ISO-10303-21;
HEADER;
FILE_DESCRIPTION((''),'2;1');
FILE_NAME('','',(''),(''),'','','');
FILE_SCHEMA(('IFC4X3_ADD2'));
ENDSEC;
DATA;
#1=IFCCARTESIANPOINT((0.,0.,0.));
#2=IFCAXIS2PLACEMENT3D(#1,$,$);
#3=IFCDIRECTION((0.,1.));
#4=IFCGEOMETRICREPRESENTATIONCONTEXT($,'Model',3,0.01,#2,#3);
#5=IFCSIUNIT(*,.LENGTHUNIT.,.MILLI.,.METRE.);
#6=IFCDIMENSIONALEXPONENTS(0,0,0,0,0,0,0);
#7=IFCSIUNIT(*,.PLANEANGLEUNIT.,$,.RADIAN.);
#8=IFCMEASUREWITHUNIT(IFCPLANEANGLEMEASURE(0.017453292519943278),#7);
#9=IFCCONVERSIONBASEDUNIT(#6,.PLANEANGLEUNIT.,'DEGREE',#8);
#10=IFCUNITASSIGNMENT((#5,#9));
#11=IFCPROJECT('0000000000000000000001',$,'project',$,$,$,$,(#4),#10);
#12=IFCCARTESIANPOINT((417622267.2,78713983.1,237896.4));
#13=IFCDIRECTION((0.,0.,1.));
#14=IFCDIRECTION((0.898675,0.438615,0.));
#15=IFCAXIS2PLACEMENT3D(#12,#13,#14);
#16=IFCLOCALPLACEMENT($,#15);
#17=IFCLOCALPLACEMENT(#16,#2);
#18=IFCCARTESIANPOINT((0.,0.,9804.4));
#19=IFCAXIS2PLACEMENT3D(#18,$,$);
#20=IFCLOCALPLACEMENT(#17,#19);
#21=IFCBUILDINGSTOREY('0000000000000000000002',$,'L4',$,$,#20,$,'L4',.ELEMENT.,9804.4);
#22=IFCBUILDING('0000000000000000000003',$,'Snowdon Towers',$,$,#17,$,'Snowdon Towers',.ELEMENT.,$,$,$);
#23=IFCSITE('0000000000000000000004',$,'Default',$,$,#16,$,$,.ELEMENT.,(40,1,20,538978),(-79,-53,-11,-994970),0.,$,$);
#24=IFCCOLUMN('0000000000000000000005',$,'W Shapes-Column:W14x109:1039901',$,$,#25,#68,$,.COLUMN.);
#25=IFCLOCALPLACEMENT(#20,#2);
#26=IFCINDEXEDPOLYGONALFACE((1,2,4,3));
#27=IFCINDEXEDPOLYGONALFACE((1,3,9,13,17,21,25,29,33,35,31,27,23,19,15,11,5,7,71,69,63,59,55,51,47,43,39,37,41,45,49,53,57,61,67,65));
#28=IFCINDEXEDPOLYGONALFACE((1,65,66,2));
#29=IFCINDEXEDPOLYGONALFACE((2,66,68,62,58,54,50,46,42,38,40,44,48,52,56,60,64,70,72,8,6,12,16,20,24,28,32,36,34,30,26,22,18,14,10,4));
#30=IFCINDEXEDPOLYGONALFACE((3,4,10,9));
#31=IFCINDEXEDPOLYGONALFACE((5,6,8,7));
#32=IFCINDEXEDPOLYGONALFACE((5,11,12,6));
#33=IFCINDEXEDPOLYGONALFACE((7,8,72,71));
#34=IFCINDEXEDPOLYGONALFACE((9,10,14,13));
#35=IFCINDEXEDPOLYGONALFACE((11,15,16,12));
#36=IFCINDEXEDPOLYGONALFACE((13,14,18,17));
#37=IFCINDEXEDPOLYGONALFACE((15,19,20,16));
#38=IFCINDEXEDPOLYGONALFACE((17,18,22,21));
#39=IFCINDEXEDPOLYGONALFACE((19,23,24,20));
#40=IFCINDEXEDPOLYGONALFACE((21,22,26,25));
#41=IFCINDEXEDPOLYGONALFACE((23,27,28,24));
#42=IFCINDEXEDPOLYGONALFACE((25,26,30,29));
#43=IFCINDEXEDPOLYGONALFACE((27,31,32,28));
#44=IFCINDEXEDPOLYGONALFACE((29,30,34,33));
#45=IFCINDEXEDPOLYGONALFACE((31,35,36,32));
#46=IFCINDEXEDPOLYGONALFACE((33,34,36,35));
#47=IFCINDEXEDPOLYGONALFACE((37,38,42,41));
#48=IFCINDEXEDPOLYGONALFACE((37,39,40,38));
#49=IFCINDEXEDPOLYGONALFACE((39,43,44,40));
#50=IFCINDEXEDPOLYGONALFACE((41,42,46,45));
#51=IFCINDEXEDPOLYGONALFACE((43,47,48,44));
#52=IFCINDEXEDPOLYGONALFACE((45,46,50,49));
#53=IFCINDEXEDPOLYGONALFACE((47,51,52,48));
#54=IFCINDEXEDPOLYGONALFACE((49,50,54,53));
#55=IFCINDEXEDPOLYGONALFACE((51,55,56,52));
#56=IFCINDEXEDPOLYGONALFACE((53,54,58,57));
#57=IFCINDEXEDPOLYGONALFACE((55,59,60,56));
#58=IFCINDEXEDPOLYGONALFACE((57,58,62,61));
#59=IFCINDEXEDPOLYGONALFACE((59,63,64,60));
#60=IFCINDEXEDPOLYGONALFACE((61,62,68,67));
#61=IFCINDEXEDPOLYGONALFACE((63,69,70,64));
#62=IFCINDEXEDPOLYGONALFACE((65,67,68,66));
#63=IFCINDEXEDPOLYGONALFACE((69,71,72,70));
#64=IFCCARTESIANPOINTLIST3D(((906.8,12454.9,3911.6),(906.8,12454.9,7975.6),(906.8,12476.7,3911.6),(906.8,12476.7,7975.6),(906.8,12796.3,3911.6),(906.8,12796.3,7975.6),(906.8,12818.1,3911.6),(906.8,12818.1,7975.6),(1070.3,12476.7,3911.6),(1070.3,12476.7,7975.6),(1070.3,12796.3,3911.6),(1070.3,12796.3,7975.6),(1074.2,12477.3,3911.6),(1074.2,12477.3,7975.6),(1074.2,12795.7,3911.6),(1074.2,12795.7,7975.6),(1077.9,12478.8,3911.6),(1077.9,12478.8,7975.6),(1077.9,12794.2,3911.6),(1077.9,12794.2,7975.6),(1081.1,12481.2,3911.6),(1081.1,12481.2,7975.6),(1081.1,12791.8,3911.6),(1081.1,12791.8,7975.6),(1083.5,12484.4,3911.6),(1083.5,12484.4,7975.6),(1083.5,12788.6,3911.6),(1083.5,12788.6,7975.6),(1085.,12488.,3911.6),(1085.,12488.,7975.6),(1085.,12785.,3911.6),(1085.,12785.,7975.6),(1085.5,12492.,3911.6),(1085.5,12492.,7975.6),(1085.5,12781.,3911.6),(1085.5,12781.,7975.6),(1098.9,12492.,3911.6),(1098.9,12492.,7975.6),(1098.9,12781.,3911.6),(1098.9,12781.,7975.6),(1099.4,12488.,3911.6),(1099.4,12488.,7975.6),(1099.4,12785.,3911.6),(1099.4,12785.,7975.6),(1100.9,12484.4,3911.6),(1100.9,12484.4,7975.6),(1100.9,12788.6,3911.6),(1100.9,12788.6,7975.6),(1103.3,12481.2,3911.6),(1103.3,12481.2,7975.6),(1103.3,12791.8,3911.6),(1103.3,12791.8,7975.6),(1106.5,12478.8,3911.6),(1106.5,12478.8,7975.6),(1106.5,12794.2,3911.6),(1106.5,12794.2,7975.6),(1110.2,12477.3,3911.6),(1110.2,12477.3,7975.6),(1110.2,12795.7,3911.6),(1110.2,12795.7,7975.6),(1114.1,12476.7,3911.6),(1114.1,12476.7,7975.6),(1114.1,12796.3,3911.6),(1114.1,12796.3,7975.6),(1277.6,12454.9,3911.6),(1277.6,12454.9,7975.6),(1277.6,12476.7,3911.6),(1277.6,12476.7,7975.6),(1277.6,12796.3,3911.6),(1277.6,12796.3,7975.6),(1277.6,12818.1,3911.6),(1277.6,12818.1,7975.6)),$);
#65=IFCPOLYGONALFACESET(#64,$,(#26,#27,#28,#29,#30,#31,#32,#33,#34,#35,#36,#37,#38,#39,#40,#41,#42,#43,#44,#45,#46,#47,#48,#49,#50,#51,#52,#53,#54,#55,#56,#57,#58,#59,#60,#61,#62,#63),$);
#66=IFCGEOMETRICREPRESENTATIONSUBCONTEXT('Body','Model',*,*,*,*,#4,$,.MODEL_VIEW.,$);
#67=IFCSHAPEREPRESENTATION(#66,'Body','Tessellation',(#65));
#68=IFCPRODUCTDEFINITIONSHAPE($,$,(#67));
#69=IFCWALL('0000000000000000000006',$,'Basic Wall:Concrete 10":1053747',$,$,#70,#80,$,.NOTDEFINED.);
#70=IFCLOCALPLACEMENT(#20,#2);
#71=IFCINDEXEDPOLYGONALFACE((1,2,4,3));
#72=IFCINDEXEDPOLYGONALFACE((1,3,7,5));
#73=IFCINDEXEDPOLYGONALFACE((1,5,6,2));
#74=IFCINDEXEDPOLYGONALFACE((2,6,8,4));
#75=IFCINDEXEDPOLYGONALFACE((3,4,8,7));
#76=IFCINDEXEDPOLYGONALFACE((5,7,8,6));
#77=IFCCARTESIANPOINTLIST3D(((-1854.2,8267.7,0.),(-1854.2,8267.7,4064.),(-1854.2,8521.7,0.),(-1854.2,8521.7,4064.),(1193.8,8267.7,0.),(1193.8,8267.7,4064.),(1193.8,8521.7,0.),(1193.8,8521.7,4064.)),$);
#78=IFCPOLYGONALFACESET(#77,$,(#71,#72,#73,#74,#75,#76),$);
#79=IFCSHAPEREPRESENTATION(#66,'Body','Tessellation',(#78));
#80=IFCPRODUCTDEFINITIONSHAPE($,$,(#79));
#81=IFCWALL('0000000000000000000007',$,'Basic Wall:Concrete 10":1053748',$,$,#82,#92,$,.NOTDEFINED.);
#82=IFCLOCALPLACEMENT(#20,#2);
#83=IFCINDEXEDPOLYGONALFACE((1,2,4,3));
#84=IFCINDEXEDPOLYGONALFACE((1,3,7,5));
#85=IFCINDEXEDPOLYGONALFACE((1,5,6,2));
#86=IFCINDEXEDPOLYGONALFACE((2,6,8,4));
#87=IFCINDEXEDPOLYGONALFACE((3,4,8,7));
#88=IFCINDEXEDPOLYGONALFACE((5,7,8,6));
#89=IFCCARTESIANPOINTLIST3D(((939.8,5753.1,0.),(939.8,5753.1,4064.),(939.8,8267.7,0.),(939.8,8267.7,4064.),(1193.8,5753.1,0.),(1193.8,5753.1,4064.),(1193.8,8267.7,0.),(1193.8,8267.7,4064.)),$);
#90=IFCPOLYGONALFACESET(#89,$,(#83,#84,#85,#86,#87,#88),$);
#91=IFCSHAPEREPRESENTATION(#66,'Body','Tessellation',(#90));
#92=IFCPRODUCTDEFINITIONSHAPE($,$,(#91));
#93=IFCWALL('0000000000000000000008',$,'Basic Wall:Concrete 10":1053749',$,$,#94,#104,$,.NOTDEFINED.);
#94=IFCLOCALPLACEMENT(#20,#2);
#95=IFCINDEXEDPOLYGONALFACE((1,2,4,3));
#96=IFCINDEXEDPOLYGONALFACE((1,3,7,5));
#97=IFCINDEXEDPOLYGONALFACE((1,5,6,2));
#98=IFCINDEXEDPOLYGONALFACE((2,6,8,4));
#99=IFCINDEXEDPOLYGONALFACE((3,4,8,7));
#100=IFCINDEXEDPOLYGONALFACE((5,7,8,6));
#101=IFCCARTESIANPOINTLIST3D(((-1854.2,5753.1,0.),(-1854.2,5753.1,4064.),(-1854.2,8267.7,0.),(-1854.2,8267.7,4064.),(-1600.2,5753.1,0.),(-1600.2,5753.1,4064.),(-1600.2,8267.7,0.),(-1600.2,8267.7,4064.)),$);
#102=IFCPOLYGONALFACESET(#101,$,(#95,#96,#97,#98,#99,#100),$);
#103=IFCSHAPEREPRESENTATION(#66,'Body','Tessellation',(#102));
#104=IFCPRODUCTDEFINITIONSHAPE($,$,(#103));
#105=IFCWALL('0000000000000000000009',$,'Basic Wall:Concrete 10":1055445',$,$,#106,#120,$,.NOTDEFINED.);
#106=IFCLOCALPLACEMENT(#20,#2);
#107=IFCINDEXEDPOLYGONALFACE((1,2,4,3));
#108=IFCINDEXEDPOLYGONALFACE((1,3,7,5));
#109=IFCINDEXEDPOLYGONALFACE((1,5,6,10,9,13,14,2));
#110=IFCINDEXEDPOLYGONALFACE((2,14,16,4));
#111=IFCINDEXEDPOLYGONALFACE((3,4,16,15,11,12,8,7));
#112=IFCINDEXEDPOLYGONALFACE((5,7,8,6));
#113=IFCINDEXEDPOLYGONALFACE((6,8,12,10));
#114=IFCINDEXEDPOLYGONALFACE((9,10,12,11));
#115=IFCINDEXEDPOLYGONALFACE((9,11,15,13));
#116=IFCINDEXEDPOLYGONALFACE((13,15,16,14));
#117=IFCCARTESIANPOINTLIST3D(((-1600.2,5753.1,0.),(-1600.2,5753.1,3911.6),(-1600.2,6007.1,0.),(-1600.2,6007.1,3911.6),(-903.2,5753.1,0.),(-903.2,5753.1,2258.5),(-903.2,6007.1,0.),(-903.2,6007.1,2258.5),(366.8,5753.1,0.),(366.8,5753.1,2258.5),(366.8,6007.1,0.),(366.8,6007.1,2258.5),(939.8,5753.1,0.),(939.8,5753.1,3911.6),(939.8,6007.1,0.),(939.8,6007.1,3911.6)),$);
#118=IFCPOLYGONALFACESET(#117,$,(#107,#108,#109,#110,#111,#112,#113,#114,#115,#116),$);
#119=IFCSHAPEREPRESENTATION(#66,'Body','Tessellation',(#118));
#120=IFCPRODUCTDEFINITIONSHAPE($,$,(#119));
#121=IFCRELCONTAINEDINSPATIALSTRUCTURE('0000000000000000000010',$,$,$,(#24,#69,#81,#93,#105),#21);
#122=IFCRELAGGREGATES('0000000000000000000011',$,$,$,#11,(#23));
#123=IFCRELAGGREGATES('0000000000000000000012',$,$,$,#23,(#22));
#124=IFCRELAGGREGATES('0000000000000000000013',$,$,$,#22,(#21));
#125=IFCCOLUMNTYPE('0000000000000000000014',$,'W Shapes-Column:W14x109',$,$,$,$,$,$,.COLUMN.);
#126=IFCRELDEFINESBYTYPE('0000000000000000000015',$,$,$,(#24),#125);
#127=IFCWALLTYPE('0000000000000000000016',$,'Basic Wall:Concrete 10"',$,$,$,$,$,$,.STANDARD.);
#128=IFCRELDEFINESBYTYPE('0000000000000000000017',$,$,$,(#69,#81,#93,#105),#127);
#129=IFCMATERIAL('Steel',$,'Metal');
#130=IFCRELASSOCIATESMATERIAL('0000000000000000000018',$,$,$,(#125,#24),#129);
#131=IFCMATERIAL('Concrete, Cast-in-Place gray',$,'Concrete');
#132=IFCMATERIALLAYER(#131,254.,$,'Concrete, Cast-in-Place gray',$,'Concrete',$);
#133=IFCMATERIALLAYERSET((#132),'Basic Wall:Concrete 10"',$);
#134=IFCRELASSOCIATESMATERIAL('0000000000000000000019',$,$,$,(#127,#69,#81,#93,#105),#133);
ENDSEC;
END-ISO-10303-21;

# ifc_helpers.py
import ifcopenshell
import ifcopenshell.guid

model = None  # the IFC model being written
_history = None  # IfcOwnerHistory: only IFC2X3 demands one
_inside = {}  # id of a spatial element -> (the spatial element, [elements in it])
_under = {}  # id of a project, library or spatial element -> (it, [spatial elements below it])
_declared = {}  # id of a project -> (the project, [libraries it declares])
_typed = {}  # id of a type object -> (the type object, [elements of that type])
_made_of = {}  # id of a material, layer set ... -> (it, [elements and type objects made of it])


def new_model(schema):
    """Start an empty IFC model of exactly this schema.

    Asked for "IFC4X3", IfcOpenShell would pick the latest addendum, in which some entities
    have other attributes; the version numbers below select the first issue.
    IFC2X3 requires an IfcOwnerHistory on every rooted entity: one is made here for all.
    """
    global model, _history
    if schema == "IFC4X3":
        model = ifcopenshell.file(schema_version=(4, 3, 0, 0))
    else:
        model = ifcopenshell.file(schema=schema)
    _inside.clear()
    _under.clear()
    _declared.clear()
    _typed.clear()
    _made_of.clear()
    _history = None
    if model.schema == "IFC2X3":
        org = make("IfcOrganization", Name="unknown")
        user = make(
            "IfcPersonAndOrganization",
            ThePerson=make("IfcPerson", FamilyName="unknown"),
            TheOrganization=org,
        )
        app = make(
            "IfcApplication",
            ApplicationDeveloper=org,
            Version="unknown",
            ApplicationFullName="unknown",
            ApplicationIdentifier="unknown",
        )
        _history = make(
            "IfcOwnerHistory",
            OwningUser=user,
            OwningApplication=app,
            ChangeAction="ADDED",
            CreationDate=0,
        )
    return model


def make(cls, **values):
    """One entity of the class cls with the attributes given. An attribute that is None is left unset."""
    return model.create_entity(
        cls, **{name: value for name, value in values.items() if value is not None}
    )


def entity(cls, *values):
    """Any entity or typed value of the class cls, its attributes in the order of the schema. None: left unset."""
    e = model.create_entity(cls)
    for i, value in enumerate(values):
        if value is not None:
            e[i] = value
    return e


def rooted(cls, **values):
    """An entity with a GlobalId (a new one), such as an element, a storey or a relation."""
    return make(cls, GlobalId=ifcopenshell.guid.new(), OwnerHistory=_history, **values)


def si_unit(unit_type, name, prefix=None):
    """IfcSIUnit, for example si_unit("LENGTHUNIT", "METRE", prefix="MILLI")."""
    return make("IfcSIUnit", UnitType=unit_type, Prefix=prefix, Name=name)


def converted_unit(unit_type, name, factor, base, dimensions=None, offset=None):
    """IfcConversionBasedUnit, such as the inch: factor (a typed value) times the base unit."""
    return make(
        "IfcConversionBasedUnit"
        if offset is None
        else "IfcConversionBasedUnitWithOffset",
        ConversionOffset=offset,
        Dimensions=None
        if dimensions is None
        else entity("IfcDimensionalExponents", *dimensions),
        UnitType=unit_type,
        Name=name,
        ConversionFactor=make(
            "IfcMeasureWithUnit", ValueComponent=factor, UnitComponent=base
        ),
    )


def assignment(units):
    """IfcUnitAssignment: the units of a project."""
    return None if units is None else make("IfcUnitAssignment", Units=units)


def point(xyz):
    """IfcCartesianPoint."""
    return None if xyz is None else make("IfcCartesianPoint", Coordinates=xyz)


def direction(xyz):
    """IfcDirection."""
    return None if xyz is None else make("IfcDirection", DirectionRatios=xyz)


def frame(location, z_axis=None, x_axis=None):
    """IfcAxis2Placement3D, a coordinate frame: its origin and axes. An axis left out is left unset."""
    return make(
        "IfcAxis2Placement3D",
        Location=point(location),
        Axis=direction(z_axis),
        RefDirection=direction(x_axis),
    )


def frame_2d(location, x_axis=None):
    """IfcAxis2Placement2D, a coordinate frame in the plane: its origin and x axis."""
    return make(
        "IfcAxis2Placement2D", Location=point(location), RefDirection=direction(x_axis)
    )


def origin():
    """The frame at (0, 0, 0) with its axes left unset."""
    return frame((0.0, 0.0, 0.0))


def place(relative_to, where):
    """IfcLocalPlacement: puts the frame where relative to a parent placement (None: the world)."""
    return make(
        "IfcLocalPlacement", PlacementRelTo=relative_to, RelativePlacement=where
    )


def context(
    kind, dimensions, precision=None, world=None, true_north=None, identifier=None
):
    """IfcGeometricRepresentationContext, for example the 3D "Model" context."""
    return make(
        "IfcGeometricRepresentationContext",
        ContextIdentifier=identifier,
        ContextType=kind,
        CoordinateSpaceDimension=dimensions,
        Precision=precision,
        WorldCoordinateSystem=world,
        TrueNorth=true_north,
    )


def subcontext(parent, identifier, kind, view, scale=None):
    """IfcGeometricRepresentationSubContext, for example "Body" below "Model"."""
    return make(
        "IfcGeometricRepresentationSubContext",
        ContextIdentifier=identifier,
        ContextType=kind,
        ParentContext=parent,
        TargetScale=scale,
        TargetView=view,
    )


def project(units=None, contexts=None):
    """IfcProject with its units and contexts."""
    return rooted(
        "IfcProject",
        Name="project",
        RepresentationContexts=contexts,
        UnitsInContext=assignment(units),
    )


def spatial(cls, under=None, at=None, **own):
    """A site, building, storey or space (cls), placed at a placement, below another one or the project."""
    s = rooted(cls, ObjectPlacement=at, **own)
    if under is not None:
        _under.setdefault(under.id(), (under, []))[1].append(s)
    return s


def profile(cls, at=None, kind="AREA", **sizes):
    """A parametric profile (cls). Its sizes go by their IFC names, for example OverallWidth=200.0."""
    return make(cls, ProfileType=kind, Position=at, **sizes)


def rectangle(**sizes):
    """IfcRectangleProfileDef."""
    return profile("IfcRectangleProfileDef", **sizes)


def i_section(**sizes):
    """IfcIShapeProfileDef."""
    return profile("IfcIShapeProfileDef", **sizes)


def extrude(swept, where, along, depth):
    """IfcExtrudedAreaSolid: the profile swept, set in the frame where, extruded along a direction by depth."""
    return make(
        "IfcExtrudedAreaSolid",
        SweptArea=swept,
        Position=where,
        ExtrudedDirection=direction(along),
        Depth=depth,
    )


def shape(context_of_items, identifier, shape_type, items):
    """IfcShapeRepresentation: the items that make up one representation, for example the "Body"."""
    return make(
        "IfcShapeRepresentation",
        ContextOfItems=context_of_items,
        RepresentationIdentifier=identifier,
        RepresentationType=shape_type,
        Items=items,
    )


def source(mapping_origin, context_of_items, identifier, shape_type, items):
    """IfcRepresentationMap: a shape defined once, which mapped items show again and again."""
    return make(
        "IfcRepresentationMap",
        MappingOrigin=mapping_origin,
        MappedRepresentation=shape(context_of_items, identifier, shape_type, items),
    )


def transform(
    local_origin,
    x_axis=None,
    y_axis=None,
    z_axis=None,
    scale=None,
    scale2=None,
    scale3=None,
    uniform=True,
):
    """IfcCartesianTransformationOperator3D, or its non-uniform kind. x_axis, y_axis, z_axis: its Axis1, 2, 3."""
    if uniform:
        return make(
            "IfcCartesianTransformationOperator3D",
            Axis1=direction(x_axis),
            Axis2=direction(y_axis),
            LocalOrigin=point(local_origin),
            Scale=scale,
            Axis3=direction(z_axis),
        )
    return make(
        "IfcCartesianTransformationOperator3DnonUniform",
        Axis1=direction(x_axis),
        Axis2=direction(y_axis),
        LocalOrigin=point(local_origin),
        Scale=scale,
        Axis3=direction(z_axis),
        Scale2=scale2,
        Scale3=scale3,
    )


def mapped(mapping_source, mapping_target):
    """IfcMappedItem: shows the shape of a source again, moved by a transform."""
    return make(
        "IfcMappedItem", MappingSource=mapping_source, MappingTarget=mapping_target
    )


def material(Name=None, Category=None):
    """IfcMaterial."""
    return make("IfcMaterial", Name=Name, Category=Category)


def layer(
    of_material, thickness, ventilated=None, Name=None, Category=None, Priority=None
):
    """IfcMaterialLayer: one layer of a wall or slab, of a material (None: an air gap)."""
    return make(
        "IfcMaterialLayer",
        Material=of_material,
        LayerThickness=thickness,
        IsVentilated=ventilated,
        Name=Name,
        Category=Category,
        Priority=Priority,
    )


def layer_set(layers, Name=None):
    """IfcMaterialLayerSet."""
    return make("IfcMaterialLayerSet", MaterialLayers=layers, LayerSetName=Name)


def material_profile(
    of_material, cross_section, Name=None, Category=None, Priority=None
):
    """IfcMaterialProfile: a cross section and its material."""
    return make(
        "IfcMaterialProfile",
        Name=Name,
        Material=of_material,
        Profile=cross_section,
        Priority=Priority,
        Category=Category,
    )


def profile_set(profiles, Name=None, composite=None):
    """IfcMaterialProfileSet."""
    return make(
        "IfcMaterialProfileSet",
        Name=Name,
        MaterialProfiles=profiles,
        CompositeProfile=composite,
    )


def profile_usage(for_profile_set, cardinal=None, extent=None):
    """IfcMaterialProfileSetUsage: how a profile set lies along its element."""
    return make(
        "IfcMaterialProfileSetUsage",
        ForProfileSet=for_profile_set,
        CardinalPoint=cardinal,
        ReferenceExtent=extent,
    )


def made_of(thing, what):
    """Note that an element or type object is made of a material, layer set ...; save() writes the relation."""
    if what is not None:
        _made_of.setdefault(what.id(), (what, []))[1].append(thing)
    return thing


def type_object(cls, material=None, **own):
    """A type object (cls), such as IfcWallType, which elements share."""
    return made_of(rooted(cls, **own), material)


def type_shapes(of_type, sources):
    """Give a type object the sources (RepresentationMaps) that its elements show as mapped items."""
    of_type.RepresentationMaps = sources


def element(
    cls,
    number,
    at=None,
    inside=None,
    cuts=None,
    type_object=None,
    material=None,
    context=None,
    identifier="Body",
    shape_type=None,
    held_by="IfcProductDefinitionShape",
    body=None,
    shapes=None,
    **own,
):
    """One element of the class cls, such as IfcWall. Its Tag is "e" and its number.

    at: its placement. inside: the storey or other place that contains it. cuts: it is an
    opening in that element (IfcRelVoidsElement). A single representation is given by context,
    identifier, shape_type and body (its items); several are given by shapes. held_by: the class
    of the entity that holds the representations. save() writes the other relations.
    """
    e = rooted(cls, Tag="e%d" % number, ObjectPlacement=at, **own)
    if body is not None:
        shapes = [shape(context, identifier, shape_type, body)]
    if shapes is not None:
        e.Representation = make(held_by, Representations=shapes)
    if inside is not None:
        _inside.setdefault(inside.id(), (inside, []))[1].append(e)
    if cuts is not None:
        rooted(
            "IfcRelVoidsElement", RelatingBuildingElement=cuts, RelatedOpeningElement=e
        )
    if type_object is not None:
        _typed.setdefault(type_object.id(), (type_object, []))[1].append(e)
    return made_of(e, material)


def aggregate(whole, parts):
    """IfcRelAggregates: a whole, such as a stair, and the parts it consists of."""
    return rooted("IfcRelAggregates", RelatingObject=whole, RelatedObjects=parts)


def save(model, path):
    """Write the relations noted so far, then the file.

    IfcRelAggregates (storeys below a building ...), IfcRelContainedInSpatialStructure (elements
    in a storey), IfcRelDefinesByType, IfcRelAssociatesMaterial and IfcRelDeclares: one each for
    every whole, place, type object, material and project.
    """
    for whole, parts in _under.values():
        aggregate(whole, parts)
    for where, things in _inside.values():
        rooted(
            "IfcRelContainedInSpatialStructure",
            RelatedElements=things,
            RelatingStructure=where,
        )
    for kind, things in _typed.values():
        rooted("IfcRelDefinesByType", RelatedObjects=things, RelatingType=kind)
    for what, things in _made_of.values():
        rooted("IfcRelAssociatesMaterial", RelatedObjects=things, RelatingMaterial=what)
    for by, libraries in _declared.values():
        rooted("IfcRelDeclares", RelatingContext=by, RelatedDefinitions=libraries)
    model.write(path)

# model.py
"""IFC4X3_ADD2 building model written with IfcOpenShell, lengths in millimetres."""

from ifc_helpers import new_model, entity, si_unit, converted_unit, direction, frame, frame_2d, origin, place, context, subcontext, project, spatial, rectangle, i_section, extrude, source, transform, mapped, material, layer, layer_set, material_profile, profile_set, profile_usage, type_object, type_shapes, element, save


model = new_model("IFC4X3_ADD2")

# Units and contexts
model_context = context("Model", 3, precision=0.01, world=origin(), true_north=direction((0.0, 1.0)))
body_context = subcontext(model_context, "Body", "Model", "MODEL_VIEW")
ifc_project = project(units=[si_unit("LENGTHUNIT", "METRE", prefix="MILLI"), converted_unit("PLANEANGLEUNIT", "DEGREE", entity("IfcPlaneAngleMeasure", 0.017453292519943278), si_unit("PLANEANGLEUNIT", "RADIAN"), dimensions=[0, 0, 0, 0, 0, 0, 0])], contexts=[model_context])

# Site, building, storey
site_placement = place(None, frame((417622267.2, 78713983.1, 237896.4), z_axis=(0.0, 0.0, 1.0), x_axis=(0.898675, 0.438615, 0.0)))
site = spatial("IfcSite", under=ifc_project, at=site_placement, Name="Default", CompositionType="ELEMENT", RefLatitude=(40, 1, 20, 538978), RefLongitude=(-79, -53, -11, -994970), RefElevation=0.0)
building_placement = place(site_placement, origin())
building = spatial("IfcBuilding", under=site, at=building_placement, Name="Snowdon Towers", LongName="Snowdon Towers", CompositionType="ELEMENT")
storey_placement = place(building_placement, frame((0.0, 0.0, 9804.4)))
storey = spatial("IfcBuildingStorey", under=building, at=storey_placement, Name="L4", LongName="L4", CompositionType="ELEMENT", Elevation=9804.4)

# Column
ifc_material_1 = material(Name="Steel", Category="Metal")
ifc_material_profile_1 = material_profile(ifc_material_1, i_section(OverallWidth=370.8, OverallDepth=363.2, WebThickness=13.3, FlangeThickness=21.8, FilletRadius=15.2, at=frame_2d((0.0, 0.0), x_axis=(1.0, 0.0))), Name="W14x109")
ifc_profile_set_1 = profile_set([ifc_material_profile_1], Name="W14x109")
ifc_profile_usage_1 = profile_usage(ifc_profile_set_1)
column_type_1 = type_object("IfcColumnType", Name="W Shapes-Column:W14x109", PredefinedType="COLUMN", material=ifc_profile_set_1)
shared_shape_1 = source(origin(), body_context, "Body", "SweptSolid", [
    extrude(i_section(OverallWidth=370.8, OverallDepth=363.2, WebThickness=13.3, FlangeThickness=21.8, FilletRadius=15.2, at=frame_2d((0.0, 0.0), x_axis=(1.0, 0.0))), frame((0.0, 0.0, 13716.0), z_axis=(0.0, 0.0, 1.0), x_axis=(-1.0, 0.0, 0.0)), (0.0, 0.0, 1.0), 4064.0),
])
type_shapes(column_type_1, [shared_shape_1])
column_1_placement = place(storey_placement, frame((1092.2, 12636.5, -9804.4), z_axis=(0.0, 0.0, 1.0), x_axis=(-1.0, 0.0, 0.0)))
element("IfcColumn", 1, at=column_1_placement, inside=storey, type_object=column_type_1, material=ifc_profile_usage_1, Name="W Shapes-Column:W14x109:1039901", PredefinedType="COLUMN", context=body_context, shape_type="MappedRepresentation", body=[
    mapped(shared_shape_1, transform((0.0, 0.0, 0.0), scale=1.0)),
])

# Walls
ifc_material_2 = material(Name="Concrete, Cast-in-Place gray", Category="Concrete")
ifc_layer = layer(ifc_material_2, 254.0, Name="Concrete, Cast-in-Place gray", Category="Concrete")
ifc_layer_set = layer_set([ifc_layer], Name="Basic Wall:Concrete 10\"")
wall_type = type_object("IfcWallType", Name="Basic Wall:Concrete 10\"", PredefinedType="STANDARD", material=ifc_layer_set)
wall_1_placement = place(storey_placement, frame((-1854.2, 8394.7, 0.0)))
element("IfcWall", 2, at=wall_1_placement, inside=storey, type_object=wall_type, material=ifc_layer_set, Name="Basic Wall:Concrete 10\":1053747", PredefinedType="NOTDEFINED", context=body_context, shape_type="SweptSolid", body=[
    extrude(rectangle(XDim=3048.0, YDim=254.0, at=frame_2d((1524.0, 0.0), x_axis=(-1.0, 0.0))), origin(), (0.0, 0.0, 1.0), 4064.0),
])
wall_2_placement = place(storey_placement, frame((1066.8, 8267.7, 0.0), z_axis=(0.0, 0.0, 1.0), x_axis=(0.0, -1.0, 0.0)))
element("IfcWall", 3, at=wall_2_placement, inside=storey, type_object=wall_type, material=ifc_layer_set, Name="Basic Wall:Concrete 10\":1053748", PredefinedType="NOTDEFINED", context=body_context, shape_type="SweptSolid", body=[
    extrude(rectangle(XDim=2514.6, YDim=254.0, at=frame_2d((1257.3, 0.0), x_axis=(-1.0, 0.0))), origin(), (0.0, 0.0, 1.0), 4064.0),
])
wall_3_placement = place(storey_placement, frame((-1727.2, 5753.1, 0.0), z_axis=(0.0, 0.0, 1.0), x_axis=(0.0, 1.0, 0.0)))
element("IfcWall", 4, at=wall_3_placement, inside=storey, type_object=wall_type, material=ifc_layer_set, Name="Basic Wall:Concrete 10\":1053749", PredefinedType="NOTDEFINED", context=body_context, shape_type="SweptSolid", body=[
    extrude(rectangle(XDim=2514.6, YDim=254.0, at=frame_2d((1257.3, 0.0), x_axis=(-1.0, 0.0))), origin(), (0.0, 0.0, 1.0), 4064.0),
])

# Wall, opening
wall_4_placement = place(storey_placement, frame((939.8, 5880.1, 0.0), z_axis=(0.0, 0.0, 1.0), x_axis=(-1.0, 0.0, 0.0)))
wall_4 = element("IfcWall", 5, at=wall_4_placement, inside=storey, type_object=wall_type, material=ifc_layer_set, Name="Basic Wall:Concrete 10\":1055445", PredefinedType="NOTDEFINED", context=body_context, shape_type="SweptSolid", body=[
    extrude(rectangle(XDim=2540.0, YDim=254.0, at=frame_2d((1270.0, 0.0), x_axis=(-1.0, 0.0))), origin(), (0.0, 0.0, 1.0), 3911.6),
])
opening_placement = place(wall_4_placement, origin())
element("IfcOpeningElement", 6, at=opening_placement, cuts=wall_4, PredefinedType="OPENING", context=body_context, shape_type="SweptSolid", body=[
    extrude(rectangle(XDim=2258.5, YDim=1270.0, at=frame_2d((0.0, 0.0), x_axis=(0.0, 1.0))), frame((1208.0, 127.0, 1129.2), z_axis=(0.0, -1.0, 0.0), x_axis=(1.0, 0.0, 0.0)), (0.0, 0.0, 1.0), 254.0),
])

save(model, "model.ifc")
